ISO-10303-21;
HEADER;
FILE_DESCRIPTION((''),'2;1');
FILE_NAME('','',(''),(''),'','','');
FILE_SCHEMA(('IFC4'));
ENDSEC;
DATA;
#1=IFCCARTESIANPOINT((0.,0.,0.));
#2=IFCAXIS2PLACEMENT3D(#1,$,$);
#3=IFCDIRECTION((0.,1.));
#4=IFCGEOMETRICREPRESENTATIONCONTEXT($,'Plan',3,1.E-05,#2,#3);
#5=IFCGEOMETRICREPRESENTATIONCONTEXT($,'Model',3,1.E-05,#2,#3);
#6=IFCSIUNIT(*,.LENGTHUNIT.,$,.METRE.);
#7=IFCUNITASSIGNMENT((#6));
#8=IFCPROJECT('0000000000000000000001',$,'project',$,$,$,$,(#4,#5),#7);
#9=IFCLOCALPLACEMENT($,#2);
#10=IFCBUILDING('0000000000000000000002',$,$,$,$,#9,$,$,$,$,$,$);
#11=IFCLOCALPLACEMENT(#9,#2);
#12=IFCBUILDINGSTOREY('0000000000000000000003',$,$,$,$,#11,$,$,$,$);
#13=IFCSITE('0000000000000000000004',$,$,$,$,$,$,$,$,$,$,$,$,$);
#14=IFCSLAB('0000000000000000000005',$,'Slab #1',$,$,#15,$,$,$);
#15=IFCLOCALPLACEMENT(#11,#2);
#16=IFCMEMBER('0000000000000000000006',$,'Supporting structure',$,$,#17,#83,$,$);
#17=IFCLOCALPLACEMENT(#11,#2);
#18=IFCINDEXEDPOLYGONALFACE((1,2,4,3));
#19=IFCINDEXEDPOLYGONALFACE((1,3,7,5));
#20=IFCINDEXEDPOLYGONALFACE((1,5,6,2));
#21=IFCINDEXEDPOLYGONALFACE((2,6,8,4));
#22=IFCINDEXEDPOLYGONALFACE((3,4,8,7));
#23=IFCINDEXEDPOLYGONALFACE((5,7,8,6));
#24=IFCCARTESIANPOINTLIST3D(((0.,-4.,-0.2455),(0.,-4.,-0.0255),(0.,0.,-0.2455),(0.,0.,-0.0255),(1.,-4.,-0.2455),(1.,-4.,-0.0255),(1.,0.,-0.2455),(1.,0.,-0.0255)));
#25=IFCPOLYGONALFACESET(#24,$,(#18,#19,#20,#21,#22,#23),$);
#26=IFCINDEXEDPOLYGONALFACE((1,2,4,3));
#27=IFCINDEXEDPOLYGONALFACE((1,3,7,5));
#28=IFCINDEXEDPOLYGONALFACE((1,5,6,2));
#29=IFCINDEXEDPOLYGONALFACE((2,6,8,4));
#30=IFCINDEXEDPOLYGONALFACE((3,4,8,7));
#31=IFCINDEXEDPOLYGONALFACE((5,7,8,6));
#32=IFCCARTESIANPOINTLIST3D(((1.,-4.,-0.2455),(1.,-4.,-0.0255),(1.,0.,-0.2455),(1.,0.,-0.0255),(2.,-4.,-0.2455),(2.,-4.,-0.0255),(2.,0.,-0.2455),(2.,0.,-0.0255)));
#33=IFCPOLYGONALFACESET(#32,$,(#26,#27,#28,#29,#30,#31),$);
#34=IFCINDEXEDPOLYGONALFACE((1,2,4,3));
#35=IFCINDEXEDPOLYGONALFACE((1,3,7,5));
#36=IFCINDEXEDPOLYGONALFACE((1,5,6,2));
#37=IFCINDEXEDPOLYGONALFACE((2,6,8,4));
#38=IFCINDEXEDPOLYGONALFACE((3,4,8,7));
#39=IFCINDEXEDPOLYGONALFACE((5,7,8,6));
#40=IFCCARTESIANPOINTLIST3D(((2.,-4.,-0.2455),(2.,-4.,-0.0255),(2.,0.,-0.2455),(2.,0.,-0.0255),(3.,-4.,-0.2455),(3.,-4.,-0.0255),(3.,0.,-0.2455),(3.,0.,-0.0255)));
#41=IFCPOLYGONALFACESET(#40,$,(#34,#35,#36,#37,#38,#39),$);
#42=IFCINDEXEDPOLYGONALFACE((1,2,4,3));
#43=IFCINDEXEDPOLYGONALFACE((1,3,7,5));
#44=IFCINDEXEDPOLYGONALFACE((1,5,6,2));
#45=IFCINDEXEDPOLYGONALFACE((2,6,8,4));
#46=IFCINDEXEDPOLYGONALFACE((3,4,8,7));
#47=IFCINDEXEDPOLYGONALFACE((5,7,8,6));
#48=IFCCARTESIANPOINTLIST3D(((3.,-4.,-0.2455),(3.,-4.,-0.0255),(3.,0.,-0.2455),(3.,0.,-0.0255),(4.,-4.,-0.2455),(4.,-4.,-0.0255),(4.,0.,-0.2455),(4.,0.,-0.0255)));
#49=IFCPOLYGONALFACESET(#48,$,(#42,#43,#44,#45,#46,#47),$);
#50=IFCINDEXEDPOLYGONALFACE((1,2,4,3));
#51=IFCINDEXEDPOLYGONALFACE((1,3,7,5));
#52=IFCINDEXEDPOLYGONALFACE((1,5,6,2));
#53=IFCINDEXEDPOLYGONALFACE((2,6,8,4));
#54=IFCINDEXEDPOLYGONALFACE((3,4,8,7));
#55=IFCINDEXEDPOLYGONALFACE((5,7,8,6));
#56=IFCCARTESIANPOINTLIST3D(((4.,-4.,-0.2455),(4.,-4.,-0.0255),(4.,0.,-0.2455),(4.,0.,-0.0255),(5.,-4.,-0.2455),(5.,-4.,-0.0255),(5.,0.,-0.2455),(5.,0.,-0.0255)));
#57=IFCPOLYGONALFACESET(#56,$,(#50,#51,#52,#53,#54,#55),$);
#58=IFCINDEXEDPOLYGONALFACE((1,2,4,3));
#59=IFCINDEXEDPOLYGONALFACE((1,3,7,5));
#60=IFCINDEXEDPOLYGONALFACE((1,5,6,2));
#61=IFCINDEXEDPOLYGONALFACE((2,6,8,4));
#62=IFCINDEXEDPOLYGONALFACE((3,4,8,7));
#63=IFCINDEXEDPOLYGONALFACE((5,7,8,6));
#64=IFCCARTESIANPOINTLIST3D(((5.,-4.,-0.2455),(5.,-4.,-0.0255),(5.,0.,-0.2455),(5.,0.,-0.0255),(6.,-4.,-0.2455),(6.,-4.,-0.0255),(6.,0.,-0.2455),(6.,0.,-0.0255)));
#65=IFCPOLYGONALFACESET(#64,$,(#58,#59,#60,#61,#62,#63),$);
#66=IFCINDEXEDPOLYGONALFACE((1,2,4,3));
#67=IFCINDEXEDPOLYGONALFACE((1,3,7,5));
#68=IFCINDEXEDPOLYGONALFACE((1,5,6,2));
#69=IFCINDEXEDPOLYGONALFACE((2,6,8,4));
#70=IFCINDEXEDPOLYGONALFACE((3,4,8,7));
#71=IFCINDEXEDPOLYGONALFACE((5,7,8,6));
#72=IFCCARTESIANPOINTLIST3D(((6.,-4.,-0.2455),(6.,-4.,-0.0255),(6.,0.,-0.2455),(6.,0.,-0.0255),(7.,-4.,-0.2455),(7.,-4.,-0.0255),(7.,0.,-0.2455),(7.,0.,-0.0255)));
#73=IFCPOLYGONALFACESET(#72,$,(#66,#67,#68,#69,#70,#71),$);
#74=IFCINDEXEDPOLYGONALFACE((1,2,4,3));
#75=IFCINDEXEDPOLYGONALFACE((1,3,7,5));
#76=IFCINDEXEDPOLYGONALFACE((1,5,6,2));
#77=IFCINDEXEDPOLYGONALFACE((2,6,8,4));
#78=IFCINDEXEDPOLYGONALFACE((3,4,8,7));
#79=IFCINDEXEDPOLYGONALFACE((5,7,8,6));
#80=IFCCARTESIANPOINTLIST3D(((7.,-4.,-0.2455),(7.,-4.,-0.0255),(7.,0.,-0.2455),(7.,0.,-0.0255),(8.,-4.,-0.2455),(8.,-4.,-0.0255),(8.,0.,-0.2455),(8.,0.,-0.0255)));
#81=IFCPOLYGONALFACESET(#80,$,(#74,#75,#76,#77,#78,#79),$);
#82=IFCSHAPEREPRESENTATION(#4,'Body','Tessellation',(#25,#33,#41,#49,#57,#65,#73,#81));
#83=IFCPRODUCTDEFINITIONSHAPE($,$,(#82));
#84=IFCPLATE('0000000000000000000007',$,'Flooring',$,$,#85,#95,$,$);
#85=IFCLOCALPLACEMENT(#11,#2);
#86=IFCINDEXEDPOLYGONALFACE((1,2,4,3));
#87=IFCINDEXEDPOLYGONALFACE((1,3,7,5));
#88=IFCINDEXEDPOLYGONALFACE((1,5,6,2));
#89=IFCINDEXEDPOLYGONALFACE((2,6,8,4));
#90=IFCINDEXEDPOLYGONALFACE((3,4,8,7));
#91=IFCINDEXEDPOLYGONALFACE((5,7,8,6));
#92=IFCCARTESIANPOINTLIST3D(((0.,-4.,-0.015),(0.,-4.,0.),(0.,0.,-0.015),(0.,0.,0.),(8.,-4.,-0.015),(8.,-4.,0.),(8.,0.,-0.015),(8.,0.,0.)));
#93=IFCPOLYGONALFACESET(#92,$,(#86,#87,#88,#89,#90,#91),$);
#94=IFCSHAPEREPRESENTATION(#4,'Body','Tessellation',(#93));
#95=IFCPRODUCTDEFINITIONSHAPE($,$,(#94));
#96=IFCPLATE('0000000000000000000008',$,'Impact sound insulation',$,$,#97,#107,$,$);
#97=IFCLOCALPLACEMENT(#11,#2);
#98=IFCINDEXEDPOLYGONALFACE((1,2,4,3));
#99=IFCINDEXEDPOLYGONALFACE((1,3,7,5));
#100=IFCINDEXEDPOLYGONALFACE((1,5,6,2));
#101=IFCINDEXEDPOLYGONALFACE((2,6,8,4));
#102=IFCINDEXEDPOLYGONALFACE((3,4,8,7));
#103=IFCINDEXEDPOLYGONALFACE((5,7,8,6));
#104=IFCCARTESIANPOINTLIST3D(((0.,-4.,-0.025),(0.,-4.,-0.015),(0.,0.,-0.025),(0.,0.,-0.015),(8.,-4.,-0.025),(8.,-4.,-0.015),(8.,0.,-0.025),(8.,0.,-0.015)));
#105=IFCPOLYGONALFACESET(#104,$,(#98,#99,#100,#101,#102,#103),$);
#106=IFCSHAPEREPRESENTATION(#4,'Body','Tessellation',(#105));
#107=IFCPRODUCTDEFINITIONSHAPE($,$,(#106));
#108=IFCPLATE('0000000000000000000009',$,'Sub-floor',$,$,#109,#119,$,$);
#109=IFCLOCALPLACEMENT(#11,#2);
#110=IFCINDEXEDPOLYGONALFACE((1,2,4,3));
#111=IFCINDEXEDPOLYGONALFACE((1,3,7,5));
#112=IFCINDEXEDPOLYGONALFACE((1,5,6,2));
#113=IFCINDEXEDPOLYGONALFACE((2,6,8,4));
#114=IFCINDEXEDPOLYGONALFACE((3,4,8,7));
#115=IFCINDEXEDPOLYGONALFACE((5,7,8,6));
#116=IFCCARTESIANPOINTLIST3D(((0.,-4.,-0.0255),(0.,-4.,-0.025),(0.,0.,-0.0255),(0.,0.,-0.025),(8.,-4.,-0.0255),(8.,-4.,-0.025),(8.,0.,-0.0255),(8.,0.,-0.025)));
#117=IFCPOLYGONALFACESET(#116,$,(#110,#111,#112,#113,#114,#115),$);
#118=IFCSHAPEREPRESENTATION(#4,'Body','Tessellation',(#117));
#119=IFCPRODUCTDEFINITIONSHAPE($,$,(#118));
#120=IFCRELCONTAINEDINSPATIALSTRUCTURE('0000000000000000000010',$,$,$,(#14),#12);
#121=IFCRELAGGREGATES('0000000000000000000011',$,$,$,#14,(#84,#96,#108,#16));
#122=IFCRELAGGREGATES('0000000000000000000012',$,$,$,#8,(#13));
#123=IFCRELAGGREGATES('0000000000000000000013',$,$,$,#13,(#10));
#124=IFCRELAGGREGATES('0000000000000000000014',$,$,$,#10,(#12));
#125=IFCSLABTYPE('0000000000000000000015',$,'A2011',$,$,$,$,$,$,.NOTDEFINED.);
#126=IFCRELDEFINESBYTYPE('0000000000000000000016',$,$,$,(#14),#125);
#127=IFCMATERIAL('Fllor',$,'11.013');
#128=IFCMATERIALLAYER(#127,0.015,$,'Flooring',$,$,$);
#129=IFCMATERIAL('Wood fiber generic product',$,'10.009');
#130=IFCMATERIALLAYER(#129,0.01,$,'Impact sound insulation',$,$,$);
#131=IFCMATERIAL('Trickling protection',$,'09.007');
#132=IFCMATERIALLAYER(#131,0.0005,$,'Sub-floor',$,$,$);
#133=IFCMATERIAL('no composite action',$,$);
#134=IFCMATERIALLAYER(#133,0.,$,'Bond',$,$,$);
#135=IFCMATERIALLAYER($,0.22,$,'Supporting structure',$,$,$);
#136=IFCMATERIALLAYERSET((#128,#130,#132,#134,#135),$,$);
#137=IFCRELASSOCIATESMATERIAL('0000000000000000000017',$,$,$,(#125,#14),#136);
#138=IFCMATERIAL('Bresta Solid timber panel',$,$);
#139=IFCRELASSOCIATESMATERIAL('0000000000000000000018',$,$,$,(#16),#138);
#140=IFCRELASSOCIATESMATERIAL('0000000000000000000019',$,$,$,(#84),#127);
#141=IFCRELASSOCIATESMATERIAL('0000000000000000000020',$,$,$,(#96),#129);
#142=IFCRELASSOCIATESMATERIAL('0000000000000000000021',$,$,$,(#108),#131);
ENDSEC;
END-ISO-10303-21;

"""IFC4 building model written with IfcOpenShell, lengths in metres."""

from ifc_helpers import new_model, si_unit, direction, frame, frame_2d, origin, origin_with_axes, place, context, project, spatial, rectangle, extrude, material, layer, layer_set, type_object, element, aggregate, save


model = new_model("IFC4")

# Units and contexts
plan_context = context("Plan", 3, precision=1e-05, world=origin(), true_north=direction((0.0, 1.0)))
model_context = context("Model", 3, precision=1e-05, world=origin(), true_north=direction((0.0, 1.0)))
ifc_project = project(units=[si_unit("LENGTHUNIT", "METRE")], contexts=[plan_context, model_context])

# Site, building, storey
site = spatial("IfcSite", under=ifc_project)
building_placement = place(None, origin())
building = spatial("IfcBuilding", under=site, at=building_placement)
storey_placement = place(building_placement, origin())
storey = spatial("IfcBuildingStorey", under=building, at=storey_placement)

# Slab, member, plates
ifc_material_1 = material(Name="Fllor", Category="11.013")
ifc_layer_1 = layer(ifc_material_1, 0.015, Name="Flooring")
ifc_material_2 = material(Name="Wood fiber generic product", Category="10.009")
ifc_layer_2 = layer(ifc_material_2, 0.01, Name="Impact sound insulation")
ifc_material_3 = material(Name="Trickling protection", Category="09.007")
ifc_layer_3 = layer(ifc_material_3, 0.0005, Name="Sub-floor")
ifc_material_4 = material(Name="no composite action")
ifc_layer_4 = layer(ifc_material_4, 0.0, Name="Bond")
ifc_layer_5 = layer(None, 0.22, Name="Supporting structure")
ifc_layer_set = layer_set([ifc_layer_1, ifc_layer_2, ifc_layer_3, ifc_layer_4, ifc_layer_5])
slab_type = type_object("IfcSlabType", Name="A2011", PredefinedType="NOTDEFINED", material=ifc_layer_set)
slab_placement = place(None, frame((0.0, 0.0, 0.0), z_axis=(0.0, 0.0, -1.0), x_axis=(1.0, 0.0, 0.0)))
slab = element("IfcSlab", 1, at=slab_placement, inside=storey, type_object=slab_type, material=ifc_layer_set, Name="Slab #1")
ifc_material_5 = material(Name="Bresta Solid timber panel")
member_placement = place(slab_placement, origin())
member = element("IfcMember", 2, at=member_placement, material=ifc_material_5, Name="Supporting structure", context=plan_context, shape_type="SweptSolid", body=[
    extrude(rectangle(XDim=1.0, YDim=0.22, at=frame_2d((0.5, 0.11), x_axis=(1.0, 0.0))), frame((0.0, 4.0, 0.0255), z_axis=(0.0, -1.0, 0.0), x_axis=(1.0, 0.0, 0.0)), (0.0, 0.0, 1.0), 4.0),
    extrude(rectangle(XDim=1.0, YDim=0.22, at=frame_2d((0.5, 0.11), x_axis=(1.0, 0.0))), frame((1.0, 4.0, 0.0255), z_axis=(0.0, -1.0, 0.0), x_axis=(1.0, 0.0, 0.0)), (0.0, 0.0, 1.0), 4.0),
    extrude(rectangle(XDim=1.0, YDim=0.22, at=frame_2d((0.5, 0.11), x_axis=(1.0, 0.0))), frame((2.0, 4.0, 0.0255), z_axis=(0.0, -1.0, 0.0), x_axis=(1.0, 0.0, 0.0)), (0.0, 0.0, 1.0), 4.0),
    extrude(rectangle(XDim=1.0, YDim=0.22, at=frame_2d((0.5, 0.11), x_axis=(1.0, 0.0))), frame((3.0, 4.0, 0.0255), z_axis=(0.0, -1.0, 0.0), x_axis=(1.0, 0.0, 0.0)), (0.0, 0.0, 1.0), 4.0),
    extrude(rectangle(XDim=1.0, YDim=0.22, at=frame_2d((0.5, 0.11), x_axis=(1.0, 0.0))), frame((4.0, 4.0, 0.0255), z_axis=(0.0, -1.0, 0.0), x_axis=(1.0, 0.0, 0.0)), (0.0, 0.0, 1.0), 4.0),
    extrude(rectangle(XDim=1.0, YDim=0.22, at=frame_2d((0.5, 0.11), x_axis=(1.0, 0.0))), frame((5.0, 4.0, 0.0255), z_axis=(0.0, -1.0, 0.0), x_axis=(1.0, 0.0, 0.0)), (0.0, 0.0, 1.0), 4.0),
    extrude(rectangle(XDim=1.0, YDim=0.22, at=frame_2d((0.5, 0.11), x_axis=(1.0, 0.0))), frame((6.0, 4.0, 0.0255), z_axis=(0.0, -1.0, 0.0), x_axis=(1.0, 0.0, 0.0)), (0.0, 0.0, 1.0), 4.0),
    extrude(rectangle(XDim=1.0, YDim=0.22, at=frame_2d((0.5, 0.11), x_axis=(1.0, 0.0))), frame((7.0, 4.0, 0.0255), z_axis=(0.0, -1.0, 0.0), x_axis=(1.0, 0.0, 0.0)), (0.0, 0.0, 1.0), 4.0),
])
plate_1_placement = place(slab_placement, origin())
plate_1 = element("IfcPlate", 3, at=plate_1_placement, material=ifc_material_1, Name="Flooring", context=plan_context, shape_type="SweptSolid", body=[
    extrude(rectangle(XDim=8.0, YDim=4.0, at=frame_2d((4.0, 2.0), x_axis=(1.0, 0.0))), origin_with_axes(), (0.0, 0.0, 1.0), 0.015),
])
plate_2_placement = place(slab_placement, origin())
plate_2 = element("IfcPlate", 4, at=plate_2_placement, material=ifc_material_2, Name="Impact sound insulation", context=plan_context, shape_type="SweptSolid", body=[
    extrude(rectangle(XDim=8.0, YDim=4.0, at=frame_2d((4.0, 2.0), x_axis=(1.0, 0.0))), frame((0.0, 0.0, 0.015), z_axis=(0.0, 0.0, 1.0), x_axis=(1.0, 0.0, 0.0)), (0.0, 0.0, 1.0), 0.01),
])
plate_3_placement = place(slab_placement, origin())
plate_3 = element("IfcPlate", 5, at=plate_3_placement, material=ifc_material_3, Name="Sub-floor", context=plan_context, shape_type="SweptSolid", body=[
    extrude(rectangle(XDim=8.0, YDim=4.0, at=frame_2d((4.0, 2.0), x_axis=(1.0, 0.0))), frame((0.0, 0.0, 0.025), z_axis=(0.0, 0.0, 1.0), x_axis=(1.0, 0.0, 0.0)), (0.0, 0.0, 1.0), 0.0005),
])
aggregate(slab, [plate_1, plate_2, plate_3, member])

save(model, "model.ifc")
